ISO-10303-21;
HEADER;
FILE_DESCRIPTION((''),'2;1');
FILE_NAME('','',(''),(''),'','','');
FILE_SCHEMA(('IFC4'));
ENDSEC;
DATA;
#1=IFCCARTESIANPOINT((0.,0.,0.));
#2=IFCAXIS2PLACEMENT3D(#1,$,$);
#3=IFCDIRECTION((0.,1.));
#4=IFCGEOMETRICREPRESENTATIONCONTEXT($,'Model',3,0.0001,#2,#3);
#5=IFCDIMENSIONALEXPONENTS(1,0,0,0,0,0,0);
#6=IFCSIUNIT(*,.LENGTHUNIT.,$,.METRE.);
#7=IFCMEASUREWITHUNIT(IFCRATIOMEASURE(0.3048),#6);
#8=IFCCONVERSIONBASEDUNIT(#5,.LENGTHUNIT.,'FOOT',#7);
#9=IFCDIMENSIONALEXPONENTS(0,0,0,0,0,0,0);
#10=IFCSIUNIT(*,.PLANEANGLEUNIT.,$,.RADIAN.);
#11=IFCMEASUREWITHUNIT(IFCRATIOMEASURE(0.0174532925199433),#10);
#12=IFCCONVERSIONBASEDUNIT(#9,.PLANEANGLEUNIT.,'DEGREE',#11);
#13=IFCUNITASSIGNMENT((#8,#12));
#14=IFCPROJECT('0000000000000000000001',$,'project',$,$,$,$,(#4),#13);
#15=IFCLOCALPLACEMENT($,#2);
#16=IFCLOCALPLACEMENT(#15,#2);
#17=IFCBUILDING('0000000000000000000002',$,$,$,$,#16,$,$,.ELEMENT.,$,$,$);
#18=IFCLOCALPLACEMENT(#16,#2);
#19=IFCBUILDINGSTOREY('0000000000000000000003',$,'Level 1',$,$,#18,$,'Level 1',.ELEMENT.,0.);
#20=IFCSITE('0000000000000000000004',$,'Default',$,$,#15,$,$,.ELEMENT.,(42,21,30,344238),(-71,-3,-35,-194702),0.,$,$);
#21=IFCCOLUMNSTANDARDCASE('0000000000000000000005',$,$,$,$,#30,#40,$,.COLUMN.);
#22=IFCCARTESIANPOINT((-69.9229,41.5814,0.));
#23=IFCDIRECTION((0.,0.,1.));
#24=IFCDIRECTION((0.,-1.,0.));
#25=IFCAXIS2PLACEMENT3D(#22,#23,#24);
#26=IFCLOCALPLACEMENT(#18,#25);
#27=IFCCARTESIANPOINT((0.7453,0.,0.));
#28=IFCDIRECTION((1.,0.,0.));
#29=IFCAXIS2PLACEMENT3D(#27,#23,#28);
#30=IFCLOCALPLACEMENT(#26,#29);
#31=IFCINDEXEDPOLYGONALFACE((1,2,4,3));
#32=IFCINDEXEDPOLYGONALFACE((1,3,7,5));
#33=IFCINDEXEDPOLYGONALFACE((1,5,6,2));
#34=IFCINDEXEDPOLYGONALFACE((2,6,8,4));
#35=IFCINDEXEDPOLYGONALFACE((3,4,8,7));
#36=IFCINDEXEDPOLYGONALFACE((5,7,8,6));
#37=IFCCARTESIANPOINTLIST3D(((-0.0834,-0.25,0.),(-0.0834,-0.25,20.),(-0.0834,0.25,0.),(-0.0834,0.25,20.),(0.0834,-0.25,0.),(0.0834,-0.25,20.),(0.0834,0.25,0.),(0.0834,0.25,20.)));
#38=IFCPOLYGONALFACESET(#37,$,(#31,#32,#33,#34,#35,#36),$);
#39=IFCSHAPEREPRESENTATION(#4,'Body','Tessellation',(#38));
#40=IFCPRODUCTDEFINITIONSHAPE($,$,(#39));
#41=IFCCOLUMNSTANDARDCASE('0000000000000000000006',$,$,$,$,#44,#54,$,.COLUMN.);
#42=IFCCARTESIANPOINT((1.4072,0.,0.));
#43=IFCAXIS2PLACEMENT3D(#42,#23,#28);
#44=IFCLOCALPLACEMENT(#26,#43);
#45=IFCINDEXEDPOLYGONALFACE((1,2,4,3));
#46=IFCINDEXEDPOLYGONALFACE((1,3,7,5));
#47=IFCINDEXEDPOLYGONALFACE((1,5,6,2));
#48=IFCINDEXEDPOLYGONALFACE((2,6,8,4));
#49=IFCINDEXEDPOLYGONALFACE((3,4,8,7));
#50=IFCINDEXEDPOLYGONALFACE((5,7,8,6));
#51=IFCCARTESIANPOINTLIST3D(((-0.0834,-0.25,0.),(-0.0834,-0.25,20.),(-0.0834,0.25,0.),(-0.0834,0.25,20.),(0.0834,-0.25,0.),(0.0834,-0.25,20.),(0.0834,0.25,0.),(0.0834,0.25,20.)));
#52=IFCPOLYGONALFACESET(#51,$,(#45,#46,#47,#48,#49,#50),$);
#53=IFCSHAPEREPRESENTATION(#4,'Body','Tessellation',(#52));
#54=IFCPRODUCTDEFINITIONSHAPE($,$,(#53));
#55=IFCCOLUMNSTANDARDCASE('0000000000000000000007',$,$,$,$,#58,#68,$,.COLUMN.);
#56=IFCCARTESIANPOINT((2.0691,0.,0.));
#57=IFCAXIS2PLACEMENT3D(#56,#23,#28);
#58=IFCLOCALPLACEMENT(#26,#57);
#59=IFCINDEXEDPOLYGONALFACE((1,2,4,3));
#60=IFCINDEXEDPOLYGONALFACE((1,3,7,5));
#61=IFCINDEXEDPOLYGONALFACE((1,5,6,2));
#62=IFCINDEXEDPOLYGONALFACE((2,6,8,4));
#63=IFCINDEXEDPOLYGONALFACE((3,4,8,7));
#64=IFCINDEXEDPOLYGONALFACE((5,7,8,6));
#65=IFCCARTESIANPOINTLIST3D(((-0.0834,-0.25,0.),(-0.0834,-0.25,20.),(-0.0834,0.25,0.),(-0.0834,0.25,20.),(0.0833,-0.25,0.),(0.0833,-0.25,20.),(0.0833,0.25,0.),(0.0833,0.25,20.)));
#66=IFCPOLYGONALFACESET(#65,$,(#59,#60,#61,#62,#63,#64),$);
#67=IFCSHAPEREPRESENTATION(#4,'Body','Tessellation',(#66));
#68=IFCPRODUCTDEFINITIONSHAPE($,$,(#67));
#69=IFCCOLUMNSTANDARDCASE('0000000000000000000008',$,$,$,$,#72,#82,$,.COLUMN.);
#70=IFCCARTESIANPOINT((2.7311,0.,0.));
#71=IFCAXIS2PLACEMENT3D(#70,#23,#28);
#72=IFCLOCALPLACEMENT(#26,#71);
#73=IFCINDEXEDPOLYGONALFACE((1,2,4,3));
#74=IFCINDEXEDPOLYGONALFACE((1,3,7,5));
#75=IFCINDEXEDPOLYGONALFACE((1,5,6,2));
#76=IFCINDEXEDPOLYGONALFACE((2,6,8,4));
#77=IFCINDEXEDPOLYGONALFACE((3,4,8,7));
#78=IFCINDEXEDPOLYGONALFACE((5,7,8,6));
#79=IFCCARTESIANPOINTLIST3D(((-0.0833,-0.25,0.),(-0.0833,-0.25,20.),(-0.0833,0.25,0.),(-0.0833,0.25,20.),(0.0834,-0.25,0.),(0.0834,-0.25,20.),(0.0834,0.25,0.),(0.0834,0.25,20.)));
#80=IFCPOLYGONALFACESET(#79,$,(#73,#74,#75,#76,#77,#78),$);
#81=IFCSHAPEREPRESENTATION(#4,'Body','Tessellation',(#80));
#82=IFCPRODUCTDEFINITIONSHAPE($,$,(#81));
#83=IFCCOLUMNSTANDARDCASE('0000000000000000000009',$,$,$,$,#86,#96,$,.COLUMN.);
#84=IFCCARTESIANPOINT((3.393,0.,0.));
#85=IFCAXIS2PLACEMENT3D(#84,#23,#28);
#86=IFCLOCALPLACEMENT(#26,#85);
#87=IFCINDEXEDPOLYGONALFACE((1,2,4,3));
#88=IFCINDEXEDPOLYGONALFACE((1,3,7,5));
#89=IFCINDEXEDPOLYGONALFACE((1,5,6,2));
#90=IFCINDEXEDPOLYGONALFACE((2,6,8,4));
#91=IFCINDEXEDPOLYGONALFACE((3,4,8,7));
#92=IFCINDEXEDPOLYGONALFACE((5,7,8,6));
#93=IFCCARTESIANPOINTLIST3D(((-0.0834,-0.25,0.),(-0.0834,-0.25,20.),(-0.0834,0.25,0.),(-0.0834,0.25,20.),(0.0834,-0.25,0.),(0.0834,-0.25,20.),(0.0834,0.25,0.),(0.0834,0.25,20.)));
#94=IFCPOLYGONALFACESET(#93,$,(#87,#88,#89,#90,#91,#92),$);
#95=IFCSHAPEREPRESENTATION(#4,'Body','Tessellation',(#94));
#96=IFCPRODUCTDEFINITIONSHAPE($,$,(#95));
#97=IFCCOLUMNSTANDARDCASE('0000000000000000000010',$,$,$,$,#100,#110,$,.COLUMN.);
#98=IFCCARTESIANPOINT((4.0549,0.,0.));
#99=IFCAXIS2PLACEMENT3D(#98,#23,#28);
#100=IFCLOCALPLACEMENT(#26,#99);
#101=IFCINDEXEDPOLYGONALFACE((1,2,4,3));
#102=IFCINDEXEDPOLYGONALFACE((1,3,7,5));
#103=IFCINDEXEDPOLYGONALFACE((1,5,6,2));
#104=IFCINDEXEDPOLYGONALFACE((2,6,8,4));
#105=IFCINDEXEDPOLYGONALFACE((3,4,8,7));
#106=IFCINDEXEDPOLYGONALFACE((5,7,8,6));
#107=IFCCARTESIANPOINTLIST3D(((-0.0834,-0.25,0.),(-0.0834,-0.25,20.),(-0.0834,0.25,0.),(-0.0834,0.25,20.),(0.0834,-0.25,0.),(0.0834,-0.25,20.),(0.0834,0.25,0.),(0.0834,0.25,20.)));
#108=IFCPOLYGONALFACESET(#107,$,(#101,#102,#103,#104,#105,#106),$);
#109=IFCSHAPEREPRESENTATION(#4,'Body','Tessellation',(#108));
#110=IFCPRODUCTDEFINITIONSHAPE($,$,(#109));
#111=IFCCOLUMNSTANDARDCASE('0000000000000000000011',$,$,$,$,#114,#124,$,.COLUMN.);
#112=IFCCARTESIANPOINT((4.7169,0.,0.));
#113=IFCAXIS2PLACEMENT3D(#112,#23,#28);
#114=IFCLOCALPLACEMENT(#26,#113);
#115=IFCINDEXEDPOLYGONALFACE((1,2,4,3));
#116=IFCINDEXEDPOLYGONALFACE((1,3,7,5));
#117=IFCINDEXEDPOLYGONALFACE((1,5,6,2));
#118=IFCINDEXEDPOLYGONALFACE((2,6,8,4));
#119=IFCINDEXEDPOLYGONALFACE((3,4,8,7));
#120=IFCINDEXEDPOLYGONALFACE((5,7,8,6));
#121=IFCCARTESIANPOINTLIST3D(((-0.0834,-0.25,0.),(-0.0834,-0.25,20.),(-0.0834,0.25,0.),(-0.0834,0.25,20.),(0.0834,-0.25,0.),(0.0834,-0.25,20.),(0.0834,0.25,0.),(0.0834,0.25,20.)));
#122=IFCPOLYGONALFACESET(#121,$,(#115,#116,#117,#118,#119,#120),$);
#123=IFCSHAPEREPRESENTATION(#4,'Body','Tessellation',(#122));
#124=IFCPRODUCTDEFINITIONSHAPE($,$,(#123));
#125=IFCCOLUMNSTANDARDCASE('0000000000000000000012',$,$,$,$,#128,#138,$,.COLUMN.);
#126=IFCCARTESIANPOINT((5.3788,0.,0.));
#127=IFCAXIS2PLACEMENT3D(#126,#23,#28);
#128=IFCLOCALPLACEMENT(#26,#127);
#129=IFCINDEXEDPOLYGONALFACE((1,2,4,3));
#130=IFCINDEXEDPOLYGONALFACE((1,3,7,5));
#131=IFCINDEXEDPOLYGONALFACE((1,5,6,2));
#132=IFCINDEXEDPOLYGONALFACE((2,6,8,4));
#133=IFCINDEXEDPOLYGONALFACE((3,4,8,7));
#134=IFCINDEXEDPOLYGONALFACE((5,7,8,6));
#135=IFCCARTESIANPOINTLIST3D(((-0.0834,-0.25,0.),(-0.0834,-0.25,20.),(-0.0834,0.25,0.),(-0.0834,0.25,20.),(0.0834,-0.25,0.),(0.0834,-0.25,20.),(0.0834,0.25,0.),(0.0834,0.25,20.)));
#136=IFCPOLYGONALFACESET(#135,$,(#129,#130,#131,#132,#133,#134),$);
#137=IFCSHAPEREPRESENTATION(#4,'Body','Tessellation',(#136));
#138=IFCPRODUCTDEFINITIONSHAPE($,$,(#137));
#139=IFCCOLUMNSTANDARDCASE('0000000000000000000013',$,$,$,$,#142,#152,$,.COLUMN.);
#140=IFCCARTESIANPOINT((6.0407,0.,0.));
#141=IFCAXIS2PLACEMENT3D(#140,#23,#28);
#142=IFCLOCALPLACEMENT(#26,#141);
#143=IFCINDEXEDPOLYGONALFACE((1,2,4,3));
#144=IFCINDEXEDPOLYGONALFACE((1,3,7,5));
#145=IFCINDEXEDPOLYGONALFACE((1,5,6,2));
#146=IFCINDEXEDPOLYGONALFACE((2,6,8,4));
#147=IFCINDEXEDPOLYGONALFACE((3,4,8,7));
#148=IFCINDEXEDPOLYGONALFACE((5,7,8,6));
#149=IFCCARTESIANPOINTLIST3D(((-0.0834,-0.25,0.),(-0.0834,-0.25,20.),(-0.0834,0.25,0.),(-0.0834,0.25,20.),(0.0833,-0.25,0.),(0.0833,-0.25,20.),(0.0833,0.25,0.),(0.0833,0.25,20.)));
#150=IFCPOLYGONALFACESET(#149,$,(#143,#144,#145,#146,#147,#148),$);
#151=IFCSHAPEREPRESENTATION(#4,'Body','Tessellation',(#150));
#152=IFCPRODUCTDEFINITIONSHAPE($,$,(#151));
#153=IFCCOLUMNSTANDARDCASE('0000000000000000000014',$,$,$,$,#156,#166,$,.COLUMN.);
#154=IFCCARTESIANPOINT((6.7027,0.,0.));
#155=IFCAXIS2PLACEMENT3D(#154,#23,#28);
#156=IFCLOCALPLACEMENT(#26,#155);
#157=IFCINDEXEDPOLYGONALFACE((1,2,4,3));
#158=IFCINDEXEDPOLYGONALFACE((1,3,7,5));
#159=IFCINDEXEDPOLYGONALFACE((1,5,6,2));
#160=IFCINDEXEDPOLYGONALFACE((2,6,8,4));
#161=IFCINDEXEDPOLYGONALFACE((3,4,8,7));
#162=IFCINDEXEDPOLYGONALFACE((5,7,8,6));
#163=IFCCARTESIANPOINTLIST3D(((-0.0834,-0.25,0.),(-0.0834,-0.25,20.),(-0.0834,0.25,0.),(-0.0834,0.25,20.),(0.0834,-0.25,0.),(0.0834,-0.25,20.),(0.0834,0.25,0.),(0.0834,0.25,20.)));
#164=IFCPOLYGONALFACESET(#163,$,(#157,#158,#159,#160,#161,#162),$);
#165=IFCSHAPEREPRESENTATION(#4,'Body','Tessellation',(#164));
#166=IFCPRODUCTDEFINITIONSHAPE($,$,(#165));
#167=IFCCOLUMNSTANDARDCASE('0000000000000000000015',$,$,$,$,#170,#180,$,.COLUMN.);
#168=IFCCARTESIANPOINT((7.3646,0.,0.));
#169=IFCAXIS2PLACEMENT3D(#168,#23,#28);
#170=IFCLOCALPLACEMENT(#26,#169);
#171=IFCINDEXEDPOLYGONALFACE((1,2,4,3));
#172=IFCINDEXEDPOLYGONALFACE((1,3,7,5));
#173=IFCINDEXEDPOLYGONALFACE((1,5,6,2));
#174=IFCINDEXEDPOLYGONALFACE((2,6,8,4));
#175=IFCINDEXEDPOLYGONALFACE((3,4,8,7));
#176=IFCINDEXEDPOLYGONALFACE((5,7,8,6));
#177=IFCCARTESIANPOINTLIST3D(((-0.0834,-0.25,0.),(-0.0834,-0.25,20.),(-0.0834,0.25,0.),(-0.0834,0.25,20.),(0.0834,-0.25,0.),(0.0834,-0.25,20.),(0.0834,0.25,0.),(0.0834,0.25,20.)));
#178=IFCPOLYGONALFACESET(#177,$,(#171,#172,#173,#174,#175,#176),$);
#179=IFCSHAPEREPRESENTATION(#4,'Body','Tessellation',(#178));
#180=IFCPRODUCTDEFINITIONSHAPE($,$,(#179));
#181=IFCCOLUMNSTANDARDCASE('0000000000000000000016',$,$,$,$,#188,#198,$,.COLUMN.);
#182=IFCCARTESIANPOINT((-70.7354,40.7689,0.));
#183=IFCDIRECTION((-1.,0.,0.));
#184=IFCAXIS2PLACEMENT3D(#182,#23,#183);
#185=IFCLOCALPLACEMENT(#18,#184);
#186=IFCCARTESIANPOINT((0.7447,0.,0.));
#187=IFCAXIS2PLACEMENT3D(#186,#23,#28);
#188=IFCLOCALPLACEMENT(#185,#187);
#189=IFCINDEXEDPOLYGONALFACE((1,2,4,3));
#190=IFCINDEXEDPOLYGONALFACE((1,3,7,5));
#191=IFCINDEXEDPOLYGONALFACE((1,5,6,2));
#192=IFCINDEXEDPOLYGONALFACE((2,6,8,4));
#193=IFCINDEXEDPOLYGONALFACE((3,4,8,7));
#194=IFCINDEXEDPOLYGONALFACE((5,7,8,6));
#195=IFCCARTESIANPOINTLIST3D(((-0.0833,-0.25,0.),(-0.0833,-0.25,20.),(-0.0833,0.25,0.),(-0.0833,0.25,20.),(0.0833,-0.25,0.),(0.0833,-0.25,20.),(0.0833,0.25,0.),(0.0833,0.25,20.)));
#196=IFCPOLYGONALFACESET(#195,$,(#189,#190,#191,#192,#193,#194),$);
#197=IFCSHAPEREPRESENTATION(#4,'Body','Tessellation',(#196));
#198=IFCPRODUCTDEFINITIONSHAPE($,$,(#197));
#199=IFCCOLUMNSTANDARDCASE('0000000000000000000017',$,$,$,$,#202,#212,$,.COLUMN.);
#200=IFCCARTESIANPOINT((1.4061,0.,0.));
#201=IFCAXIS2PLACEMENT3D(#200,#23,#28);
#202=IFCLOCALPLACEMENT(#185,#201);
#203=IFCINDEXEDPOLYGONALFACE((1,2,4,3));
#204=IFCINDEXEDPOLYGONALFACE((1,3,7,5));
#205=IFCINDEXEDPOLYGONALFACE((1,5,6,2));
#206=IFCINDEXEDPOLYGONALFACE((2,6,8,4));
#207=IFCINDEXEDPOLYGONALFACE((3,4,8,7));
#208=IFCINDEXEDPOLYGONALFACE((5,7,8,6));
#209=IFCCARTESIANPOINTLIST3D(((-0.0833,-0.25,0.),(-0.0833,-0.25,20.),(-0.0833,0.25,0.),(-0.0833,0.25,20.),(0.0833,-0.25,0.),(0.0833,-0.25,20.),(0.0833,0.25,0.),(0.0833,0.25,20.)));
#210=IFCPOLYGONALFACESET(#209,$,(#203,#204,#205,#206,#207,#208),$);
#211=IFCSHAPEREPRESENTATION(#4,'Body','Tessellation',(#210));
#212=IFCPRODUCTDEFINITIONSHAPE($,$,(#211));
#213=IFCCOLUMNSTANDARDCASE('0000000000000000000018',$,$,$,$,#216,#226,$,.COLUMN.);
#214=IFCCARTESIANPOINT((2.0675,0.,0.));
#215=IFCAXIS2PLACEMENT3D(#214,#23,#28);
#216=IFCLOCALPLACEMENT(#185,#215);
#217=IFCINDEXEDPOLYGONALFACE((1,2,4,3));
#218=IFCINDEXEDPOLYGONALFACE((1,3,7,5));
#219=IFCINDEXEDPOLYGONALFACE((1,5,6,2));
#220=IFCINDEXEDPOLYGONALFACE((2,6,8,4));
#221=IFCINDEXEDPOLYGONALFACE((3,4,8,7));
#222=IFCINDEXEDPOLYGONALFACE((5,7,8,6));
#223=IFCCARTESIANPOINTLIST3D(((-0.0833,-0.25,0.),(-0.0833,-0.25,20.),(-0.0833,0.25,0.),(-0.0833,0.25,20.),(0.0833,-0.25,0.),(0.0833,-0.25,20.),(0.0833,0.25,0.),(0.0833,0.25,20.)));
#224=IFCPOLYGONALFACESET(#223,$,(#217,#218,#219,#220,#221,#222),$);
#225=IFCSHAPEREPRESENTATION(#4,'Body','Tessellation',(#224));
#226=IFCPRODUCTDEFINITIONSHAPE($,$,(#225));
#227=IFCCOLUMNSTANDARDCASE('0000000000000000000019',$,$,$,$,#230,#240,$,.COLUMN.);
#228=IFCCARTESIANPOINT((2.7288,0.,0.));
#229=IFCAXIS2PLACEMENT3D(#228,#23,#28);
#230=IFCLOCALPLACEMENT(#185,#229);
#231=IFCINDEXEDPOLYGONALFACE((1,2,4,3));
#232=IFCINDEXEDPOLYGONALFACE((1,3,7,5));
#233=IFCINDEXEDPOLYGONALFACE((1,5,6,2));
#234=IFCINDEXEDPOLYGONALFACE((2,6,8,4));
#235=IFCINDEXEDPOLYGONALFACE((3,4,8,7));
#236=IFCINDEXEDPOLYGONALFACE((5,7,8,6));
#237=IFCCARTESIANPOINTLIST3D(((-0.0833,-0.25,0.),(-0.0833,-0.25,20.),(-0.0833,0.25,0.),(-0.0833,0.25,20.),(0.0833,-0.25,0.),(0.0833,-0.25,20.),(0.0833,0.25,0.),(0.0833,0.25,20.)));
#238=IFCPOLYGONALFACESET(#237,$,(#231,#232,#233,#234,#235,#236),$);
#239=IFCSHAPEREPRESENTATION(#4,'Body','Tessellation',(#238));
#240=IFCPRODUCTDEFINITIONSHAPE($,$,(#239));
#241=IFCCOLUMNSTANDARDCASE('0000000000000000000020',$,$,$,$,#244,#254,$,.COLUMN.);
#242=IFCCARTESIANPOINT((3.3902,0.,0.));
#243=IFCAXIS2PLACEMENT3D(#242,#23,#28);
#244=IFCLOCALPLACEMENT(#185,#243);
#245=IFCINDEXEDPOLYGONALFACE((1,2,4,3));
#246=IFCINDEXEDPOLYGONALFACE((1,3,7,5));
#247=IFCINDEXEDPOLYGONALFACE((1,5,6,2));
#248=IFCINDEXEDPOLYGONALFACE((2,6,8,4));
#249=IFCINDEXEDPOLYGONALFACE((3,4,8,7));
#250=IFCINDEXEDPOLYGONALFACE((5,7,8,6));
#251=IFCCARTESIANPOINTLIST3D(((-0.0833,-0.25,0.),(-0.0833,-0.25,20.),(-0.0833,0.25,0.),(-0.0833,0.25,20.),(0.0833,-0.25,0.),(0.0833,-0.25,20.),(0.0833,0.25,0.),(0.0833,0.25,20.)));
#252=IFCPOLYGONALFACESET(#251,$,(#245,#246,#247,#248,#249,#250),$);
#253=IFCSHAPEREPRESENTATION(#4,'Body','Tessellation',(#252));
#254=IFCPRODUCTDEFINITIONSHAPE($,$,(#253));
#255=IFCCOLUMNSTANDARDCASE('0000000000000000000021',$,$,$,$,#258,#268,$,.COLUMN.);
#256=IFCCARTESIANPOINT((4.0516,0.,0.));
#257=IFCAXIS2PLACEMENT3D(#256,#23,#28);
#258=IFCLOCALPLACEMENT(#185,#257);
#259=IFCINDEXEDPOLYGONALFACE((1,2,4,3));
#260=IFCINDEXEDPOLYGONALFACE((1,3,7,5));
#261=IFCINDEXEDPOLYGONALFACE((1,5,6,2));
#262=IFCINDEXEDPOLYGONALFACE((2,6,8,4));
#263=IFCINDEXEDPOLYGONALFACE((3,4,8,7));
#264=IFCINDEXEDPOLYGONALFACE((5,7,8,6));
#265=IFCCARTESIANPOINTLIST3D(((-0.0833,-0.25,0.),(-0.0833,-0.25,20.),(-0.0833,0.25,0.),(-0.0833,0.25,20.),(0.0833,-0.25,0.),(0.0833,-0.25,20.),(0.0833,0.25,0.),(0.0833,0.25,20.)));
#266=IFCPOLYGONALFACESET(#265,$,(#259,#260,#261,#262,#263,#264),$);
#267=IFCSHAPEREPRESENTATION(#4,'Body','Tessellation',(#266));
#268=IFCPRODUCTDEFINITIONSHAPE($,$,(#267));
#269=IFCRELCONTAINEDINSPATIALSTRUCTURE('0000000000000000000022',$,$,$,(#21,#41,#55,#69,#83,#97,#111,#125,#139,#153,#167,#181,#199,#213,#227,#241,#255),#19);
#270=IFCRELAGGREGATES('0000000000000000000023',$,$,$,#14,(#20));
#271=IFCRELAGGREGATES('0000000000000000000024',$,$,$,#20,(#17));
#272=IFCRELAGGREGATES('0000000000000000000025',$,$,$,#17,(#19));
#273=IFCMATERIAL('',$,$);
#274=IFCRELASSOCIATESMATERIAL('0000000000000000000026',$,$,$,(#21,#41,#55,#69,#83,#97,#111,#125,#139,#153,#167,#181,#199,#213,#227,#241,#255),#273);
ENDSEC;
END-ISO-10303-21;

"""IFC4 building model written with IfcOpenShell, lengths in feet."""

from ifc_helpers import new_model, entity, si_unit, converted_unit, direction, frame, origin, place, context, project, spatial, rectangle, extrude, material, element, save


model = new_model("IFC4")

# Units and contexts
model_context = context("Model", 3, precision=0.0001, world=origin(), true_north=direction((0.0, 1.0)))
ifc_project = project(units=[converted_unit("LENGTHUNIT", "FOOT", entity("IfcRatioMeasure", 0.3048), si_unit("LENGTHUNIT", "METRE"), dimensions=[1, 0, 0, 0, 0, 0, 0]), converted_unit("PLANEANGLEUNIT", "DEGREE", entity("IfcRatioMeasure", 0.0174532925199433), si_unit("PLANEANGLEUNIT", "RADIAN"), dimensions=[0, 0, 0, 0, 0, 0, 0])], contexts=[model_context])

# Site, building, storey
site_placement = place(None, origin())
site = spatial("IfcSite", under=ifc_project, at=site_placement, Name="Default", CompositionType="ELEMENT", RefLatitude=(42, 21, 30, 344238), RefLongitude=(-71, -3, -35, -194702), RefElevation=0.0)
building_placement = place(site_placement, origin())
building = spatial("IfcBuilding", under=site, at=building_placement, CompositionType="ELEMENT")
storey_placement = place(building_placement, origin())
storey = spatial("IfcBuildingStorey", under=building, at=storey_placement, Name="Level 1", LongName="Level 1", CompositionType="ELEMENT", Elevation=0.0)

# Columns
ifc_material_1 = material(Name="")
wall_1_placement = place(storey_placement, frame((-69.9229, 41.5814, 0.0), z_axis=(0.0, 0.0, 1.0), x_axis=(0.0, -1.0, 0.0)))
for number, where, z_axis, x_axis in (
    (1, (0.7453, 0.0, 0.0), (0.0, 0.0, 1.0), (1.0, 0.0, 0.0)),
    (2, (1.4072, 0.0, 0.0), (0.0, 0.0, 1.0), (1.0, 0.0, 0.0)),
    (3, (2.0691, 0.0, 0.0), (0.0, 0.0, 1.0), (1.0, 0.0, 0.0)),
    (4, (2.7311, 0.0, 0.0), (0.0, 0.0, 1.0), (1.0, 0.0, 0.0)),
    (5, (3.393, 0.0, 0.0), (0.0, 0.0, 1.0), (1.0, 0.0, 0.0)),
    (6, (4.0549, 0.0, 0.0), (0.0, 0.0, 1.0), (1.0, 0.0, 0.0)),
    (7, (4.7169, 0.0, 0.0), (0.0, 0.0, 1.0), (1.0, 0.0, 0.0)),
    (8, (5.3788, 0.0, 0.0), (0.0, 0.0, 1.0), (1.0, 0.0, 0.0)),
    (9, (6.0407, 0.0, 0.0), (0.0, 0.0, 1.0), (1.0, 0.0, 0.0)),
    (10, (6.7027, 0.0, 0.0), (0.0, 0.0, 1.0), (1.0, 0.0, 0.0)),
    (11, (7.3646, 0.0, 0.0), (0.0, 0.0, 1.0), (1.0, 0.0, 0.0)),
):
    element("IfcColumnStandardCase", number, at=place(wall_1_placement, frame(where, z_axis=z_axis, x_axis=x_axis)), inside=storey, material=ifc_material_1, PredefinedType="COLUMN", context=model_context, shape_type="SweptSolid", body=[
        extrude(rectangle(XDim=0.1667, YDim=0.5), origin(), (0.0, 0.0, 1.0), 20.0),
    ])
wall_2_placement = place(storey_placement, frame((-70.7354, 40.7689, 0.0), z_axis=(0.0, 0.0, 1.0), x_axis=(-1.0, 0.0, 0.0)))
for number, where, z_axis, x_axis in (
    (12, (0.7447, 0.0, 0.0), (0.0, 0.0, 1.0), (1.0, 0.0, 0.0)),
    (13, (1.4061, 0.0, 0.0), (0.0, 0.0, 1.0), (1.0, 0.0, 0.0)),
    (14, (2.0675, 0.0, 0.0), (0.0, 0.0, 1.0), (1.0, 0.0, 0.0)),
    (15, (2.7288, 0.0, 0.0), (0.0, 0.0, 1.0), (1.0, 0.0, 0.0)),
    (16, (3.3902, 0.0, 0.0), (0.0, 0.0, 1.0), (1.0, 0.0, 0.0)),
    (17, (4.0516, 0.0, 0.0), (0.0, 0.0, 1.0), (1.0, 0.0, 0.0)),
):
    element("IfcColumnStandardCase", number, at=place(wall_2_placement, frame(where, z_axis=z_axis, x_axis=x_axis)), inside=storey, material=ifc_material_1, PredefinedType="COLUMN", context=model_context, shape_type="SweptSolid", body=[
        extrude(rectangle(XDim=0.1667, YDim=0.5), origin(), (0.0, 0.0, 1.0), 20.0),
    ])

save(model, "model.ifc")
